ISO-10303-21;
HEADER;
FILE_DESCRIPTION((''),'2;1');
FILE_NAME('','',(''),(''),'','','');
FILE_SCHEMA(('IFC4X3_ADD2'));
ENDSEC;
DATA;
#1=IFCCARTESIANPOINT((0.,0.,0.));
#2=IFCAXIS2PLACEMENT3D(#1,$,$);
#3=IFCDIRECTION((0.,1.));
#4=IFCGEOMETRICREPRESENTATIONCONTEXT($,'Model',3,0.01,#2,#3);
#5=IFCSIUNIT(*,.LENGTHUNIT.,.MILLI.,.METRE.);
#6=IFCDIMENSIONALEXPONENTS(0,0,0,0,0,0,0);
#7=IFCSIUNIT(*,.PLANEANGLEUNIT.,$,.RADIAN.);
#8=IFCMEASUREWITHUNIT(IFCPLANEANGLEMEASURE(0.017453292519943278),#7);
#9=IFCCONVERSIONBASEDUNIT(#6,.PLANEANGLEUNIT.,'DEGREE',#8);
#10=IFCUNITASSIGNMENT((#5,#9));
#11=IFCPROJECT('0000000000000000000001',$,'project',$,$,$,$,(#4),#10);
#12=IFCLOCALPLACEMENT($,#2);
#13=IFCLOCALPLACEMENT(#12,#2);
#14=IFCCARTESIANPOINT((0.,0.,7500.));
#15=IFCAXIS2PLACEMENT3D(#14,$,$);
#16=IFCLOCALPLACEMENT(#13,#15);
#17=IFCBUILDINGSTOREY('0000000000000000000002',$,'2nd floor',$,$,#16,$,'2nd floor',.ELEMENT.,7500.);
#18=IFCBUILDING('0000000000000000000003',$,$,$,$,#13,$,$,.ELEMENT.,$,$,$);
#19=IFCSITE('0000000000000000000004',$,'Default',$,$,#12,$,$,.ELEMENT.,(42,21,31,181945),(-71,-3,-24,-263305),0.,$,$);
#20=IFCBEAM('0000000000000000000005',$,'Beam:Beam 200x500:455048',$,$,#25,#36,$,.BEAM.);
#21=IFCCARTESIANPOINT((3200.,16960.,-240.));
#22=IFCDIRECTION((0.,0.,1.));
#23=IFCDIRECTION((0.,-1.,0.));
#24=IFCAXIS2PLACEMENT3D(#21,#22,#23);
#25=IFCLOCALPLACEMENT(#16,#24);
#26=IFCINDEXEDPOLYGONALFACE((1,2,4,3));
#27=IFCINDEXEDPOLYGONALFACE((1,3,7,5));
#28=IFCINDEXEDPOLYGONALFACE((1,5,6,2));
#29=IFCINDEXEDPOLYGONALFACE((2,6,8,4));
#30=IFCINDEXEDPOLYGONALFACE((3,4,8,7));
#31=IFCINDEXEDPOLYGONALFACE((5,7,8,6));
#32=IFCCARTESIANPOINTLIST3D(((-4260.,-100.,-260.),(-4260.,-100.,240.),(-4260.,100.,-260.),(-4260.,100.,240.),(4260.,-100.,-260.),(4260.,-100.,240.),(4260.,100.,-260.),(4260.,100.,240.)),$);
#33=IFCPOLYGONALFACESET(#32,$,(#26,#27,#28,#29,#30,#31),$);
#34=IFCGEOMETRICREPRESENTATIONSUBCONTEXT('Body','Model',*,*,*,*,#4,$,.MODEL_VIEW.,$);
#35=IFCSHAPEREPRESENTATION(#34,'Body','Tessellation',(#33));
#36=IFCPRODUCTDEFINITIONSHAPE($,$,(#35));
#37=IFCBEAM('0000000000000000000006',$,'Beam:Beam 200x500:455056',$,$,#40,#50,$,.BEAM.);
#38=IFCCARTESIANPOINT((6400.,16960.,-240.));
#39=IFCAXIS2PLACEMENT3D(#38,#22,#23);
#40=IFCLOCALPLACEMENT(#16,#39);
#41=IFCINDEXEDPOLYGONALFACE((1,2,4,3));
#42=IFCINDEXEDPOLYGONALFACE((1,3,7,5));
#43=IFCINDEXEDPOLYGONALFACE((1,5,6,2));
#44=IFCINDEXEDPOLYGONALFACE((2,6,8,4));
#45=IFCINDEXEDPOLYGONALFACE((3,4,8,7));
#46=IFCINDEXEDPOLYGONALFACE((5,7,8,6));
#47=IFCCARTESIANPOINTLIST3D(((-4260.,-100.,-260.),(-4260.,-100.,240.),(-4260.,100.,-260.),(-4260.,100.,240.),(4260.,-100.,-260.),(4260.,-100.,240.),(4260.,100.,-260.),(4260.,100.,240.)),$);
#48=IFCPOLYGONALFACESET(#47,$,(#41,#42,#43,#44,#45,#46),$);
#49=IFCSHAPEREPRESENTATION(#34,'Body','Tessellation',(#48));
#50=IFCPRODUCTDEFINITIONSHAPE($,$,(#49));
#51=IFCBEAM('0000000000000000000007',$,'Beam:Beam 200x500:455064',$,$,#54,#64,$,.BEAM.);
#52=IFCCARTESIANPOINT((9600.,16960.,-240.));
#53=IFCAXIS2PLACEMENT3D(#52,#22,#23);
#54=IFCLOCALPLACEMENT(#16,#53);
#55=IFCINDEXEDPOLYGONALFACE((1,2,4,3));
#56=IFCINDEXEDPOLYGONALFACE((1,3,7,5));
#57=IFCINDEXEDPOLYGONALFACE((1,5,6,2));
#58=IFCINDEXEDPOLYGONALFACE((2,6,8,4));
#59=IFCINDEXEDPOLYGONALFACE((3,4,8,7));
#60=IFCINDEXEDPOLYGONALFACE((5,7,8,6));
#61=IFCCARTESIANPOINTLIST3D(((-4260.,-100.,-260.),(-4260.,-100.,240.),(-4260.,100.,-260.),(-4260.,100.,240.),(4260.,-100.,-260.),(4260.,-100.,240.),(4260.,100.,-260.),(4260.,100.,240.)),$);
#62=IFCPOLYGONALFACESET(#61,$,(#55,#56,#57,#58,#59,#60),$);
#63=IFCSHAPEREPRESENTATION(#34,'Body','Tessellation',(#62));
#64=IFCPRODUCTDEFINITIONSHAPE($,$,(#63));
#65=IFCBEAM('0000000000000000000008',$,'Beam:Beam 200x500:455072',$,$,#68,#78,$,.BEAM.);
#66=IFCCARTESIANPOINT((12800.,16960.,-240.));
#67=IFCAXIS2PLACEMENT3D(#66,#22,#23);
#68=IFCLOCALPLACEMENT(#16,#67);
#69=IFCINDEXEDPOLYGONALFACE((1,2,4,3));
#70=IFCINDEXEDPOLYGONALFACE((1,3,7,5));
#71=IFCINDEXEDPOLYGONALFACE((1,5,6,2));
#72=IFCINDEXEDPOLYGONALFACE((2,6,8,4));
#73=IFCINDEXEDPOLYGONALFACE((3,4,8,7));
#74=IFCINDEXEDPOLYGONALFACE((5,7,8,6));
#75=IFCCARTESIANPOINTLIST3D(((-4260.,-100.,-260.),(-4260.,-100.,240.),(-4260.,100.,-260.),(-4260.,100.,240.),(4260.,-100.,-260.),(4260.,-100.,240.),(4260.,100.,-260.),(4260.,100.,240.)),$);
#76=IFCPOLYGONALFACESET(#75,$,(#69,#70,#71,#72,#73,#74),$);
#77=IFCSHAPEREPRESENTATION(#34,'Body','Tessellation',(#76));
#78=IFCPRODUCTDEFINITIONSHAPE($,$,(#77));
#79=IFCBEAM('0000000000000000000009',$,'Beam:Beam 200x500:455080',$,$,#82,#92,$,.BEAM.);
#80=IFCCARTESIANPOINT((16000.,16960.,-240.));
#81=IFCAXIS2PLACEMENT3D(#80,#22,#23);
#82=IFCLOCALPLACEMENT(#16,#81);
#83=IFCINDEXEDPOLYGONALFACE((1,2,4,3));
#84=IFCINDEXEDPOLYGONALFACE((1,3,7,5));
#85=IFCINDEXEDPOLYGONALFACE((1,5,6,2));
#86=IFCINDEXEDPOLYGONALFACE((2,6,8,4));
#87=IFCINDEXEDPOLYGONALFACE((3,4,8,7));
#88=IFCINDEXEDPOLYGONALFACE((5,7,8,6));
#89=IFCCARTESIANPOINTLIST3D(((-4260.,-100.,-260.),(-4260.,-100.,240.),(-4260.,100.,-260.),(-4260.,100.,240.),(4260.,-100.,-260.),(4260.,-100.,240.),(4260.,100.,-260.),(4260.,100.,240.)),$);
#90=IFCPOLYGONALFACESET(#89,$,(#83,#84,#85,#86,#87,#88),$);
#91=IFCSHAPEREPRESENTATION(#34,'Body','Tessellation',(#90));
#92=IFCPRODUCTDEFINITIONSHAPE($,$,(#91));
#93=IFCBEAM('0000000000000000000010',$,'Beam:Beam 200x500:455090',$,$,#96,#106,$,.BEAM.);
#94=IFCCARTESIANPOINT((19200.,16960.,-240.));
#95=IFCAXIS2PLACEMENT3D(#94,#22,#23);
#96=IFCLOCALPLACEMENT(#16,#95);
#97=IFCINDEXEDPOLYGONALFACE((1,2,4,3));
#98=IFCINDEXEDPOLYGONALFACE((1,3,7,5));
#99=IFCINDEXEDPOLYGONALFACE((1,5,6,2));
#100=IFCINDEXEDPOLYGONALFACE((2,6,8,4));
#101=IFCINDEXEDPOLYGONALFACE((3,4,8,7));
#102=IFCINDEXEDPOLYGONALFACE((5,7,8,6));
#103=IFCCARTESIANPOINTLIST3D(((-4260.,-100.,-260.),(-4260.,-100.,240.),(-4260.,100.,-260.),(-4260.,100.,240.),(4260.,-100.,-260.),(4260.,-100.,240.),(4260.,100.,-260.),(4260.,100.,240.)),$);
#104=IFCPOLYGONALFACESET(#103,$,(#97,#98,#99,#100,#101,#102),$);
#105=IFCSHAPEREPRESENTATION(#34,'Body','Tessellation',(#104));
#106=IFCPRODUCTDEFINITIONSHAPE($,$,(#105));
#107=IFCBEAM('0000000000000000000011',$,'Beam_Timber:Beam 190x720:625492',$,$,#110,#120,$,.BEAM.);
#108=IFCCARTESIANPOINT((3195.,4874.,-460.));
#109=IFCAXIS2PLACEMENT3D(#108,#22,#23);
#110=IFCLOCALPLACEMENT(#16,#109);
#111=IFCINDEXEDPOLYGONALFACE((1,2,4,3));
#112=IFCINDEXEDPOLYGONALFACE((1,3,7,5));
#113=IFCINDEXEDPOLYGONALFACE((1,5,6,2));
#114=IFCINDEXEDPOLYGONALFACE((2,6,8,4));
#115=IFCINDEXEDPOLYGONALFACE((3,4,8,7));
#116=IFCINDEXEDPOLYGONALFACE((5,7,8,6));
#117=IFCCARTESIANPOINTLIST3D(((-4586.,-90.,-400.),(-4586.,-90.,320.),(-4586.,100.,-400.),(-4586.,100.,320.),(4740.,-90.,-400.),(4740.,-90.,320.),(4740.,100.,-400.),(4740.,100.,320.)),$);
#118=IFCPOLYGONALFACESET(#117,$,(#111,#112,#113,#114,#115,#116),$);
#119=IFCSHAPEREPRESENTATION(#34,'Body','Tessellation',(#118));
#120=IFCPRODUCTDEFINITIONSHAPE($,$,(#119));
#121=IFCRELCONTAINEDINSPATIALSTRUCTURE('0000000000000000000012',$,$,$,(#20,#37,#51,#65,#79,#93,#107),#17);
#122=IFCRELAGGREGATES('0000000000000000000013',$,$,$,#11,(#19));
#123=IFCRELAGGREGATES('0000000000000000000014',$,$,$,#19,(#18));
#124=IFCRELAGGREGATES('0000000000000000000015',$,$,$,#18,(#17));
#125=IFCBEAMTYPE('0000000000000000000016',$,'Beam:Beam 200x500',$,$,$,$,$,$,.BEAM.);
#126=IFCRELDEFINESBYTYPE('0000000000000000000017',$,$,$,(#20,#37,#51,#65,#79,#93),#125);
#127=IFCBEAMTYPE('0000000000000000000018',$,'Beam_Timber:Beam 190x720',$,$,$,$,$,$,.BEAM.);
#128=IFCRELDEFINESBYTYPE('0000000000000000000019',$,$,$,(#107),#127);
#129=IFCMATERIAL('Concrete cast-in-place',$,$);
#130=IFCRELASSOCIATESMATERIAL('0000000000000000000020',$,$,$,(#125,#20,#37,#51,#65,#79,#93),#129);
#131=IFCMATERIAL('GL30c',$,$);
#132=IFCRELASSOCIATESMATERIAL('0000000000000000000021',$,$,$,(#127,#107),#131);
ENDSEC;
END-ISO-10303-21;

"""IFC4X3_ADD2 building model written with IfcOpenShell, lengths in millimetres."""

from ifc_helpers import new_model, entity, si_unit, converted_unit, direction, frame, origin, origin_2d_with_axis, place, context, subcontext, project, spatial, rectangle, extrude, source, transform, mapped, material, material_profile, profile_set, profile_usage, type_object, type_shapes, element, save


model = new_model("IFC4X3_ADD2")

# Units and contexts
model_context = context("Model", 3, precision=0.01, world=origin(), true_north=direction((0.0, 1.0)))
body_context = subcontext(model_context, "Body", "Model", "MODEL_VIEW")
ifc_project = project(units=[si_unit("LENGTHUNIT", "METRE", prefix="MILLI"), converted_unit("PLANEANGLEUNIT", "DEGREE", entity("IfcPlaneAngleMeasure", 0.017453292519943278), si_unit("PLANEANGLEUNIT", "RADIAN"), dimensions=[0, 0, 0, 0, 0, 0, 0])], contexts=[model_context])

# Site, building, storey
site_placement = place(None, origin())
site = spatial("IfcSite", under=ifc_project, at=site_placement, Name="Default", CompositionType="ELEMENT", RefLatitude=(42, 21, 31, 181945), RefLongitude=(-71, -3, -24, -263305), RefElevation=0.0)
building_placement = place(site_placement, origin())
building = spatial("IfcBuilding", under=site, at=building_placement, CompositionType="ELEMENT")
storey_placement = place(building_placement, frame((0.0, 0.0, 7500.0)))
storey = spatial("IfcBuildingStorey", under=building, at=storey_placement, Name="2nd floor", LongName="2nd floor", CompositionType="ELEMENT", Elevation=7500.0)

# Beams
ifc_material_1 = material(Name="Concrete cast-in-place")
ifc_material_profile_1 = material_profile(ifc_material_1, rectangle(XDim=8600.0, YDim=200.0, at=origin_2d_with_axis()), Name="Beam 200x500")
ifc_profile_set_1 = profile_set([ifc_material_profile_1], Name="Beam 200x500")
ifc_profile_usage_1 = profile_usage(ifc_profile_set_1, cardinal=8)
beam_type_1 = type_object("IfcBeamType", Name="Beam:Beam 200x500", PredefinedType="BEAM", material=ifc_profile_set_1)
shared_shape_1 = source(origin(), body_context, "Body", "SweptSolid", [
    extrude(rectangle(XDim=8520.0, YDim=200.0, at=origin_2d_with_axis()), frame((0.0, 0.0, -260.0), z_axis=(0.0, 0.0, 1.0), x_axis=(-1.0, 0.0, 0.0)), (0.0, 0.0, 1.0), 500.0),
])
type_shapes(beam_type_1, [shared_shape_1])
for number, where, z_axis, x_axis, name in (
    (1, (3200.0, 16960.0, -240.0), (0.0, 0.0, 1.0), (0.0, -1.0, 0.0), "Beam:Beam 200x500:455048"),
    (2, (6400.0, 16960.0, -240.0), (0.0, 0.0, 1.0), (0.0, -1.0, 0.0), "Beam:Beam 200x500:455056"),
    (3, (9600.0, 16960.0, -240.0), (0.0, 0.0, 1.0), (0.0, -1.0, 0.0), "Beam:Beam 200x500:455064"),
    (4, (12800.0, 16960.0, -240.0), (0.0, 0.0, 1.0), (0.0, -1.0, 0.0), "Beam:Beam 200x500:455072"),
    (5, (16000.0, 16960.0, -240.0), (0.0, 0.0, 1.0), (0.0, -1.0, 0.0), "Beam:Beam 200x500:455080"),
    (6, (19200.0, 16960.0, -240.0), (0.0, 0.0, 1.0), (0.0, -1.0, 0.0), "Beam:Beam 200x500:455090"),
):
    element("IfcBeam", number, at=place(storey_placement, frame(where, z_axis=z_axis, x_axis=x_axis)), inside=storey, type_object=beam_type_1, material=ifc_profile_usage_1, Name=name, PredefinedType="BEAM", context=body_context, shape_type="MappedRepresentation", body=[
        mapped(shared_shape_1, transform((0.0, 0.0, 0.0), scale=1.0)),
    ])
ifc_material_2 = material(Name="GL30c")
ifc_material_profile_2 = material_profile(ifc_material_2, rectangle(XDim=9326.0, YDim=190.0, at=origin_2d_with_axis()), Name="Beam 190x720")
ifc_profile_set_2 = profile_set([ifc_material_profile_2], Name="Beam 190x720")
ifc_profile_usage_2 = profile_usage(ifc_profile_set_2, cardinal=8)
beam_type_2 = type_object("IfcBeamType", Name="Beam_Timber:Beam 190x720", PredefinedType="BEAM", material=ifc_profile_set_2)
shared_shape_2 = source(origin(), body_context, "Body", "SweptSolid", [
    extrude(rectangle(XDim=9326.0, YDim=190.0, at=origin_2d_with_axis()), frame((77.0, 5.0, -400.0), z_axis=(0.0, 0.0, 1.0), x_axis=(-1.0, 0.0, 0.0)), (0.0, 0.0, 1.0), 720.0),
])
type_shapes(beam_type_2, [shared_shape_2])
beam_1_placement = place(storey_placement, frame((3195.0, 4874.0, -460.0), z_axis=(0.0, 0.0, 1.0), x_axis=(0.0, -1.0, 0.0)))
element("IfcBeam", 7, at=beam_1_placement, inside=storey, type_object=beam_type_2, material=ifc_profile_usage_2, Name="Beam_Timber:Beam 190x720:625492", PredefinedType="BEAM", context=body_context, shape_type="MappedRepresentation", body=[
    mapped(shared_shape_2, transform((0.0, 0.0, 0.0), scale=1.0)),
])

save(model, "model.ifc")
